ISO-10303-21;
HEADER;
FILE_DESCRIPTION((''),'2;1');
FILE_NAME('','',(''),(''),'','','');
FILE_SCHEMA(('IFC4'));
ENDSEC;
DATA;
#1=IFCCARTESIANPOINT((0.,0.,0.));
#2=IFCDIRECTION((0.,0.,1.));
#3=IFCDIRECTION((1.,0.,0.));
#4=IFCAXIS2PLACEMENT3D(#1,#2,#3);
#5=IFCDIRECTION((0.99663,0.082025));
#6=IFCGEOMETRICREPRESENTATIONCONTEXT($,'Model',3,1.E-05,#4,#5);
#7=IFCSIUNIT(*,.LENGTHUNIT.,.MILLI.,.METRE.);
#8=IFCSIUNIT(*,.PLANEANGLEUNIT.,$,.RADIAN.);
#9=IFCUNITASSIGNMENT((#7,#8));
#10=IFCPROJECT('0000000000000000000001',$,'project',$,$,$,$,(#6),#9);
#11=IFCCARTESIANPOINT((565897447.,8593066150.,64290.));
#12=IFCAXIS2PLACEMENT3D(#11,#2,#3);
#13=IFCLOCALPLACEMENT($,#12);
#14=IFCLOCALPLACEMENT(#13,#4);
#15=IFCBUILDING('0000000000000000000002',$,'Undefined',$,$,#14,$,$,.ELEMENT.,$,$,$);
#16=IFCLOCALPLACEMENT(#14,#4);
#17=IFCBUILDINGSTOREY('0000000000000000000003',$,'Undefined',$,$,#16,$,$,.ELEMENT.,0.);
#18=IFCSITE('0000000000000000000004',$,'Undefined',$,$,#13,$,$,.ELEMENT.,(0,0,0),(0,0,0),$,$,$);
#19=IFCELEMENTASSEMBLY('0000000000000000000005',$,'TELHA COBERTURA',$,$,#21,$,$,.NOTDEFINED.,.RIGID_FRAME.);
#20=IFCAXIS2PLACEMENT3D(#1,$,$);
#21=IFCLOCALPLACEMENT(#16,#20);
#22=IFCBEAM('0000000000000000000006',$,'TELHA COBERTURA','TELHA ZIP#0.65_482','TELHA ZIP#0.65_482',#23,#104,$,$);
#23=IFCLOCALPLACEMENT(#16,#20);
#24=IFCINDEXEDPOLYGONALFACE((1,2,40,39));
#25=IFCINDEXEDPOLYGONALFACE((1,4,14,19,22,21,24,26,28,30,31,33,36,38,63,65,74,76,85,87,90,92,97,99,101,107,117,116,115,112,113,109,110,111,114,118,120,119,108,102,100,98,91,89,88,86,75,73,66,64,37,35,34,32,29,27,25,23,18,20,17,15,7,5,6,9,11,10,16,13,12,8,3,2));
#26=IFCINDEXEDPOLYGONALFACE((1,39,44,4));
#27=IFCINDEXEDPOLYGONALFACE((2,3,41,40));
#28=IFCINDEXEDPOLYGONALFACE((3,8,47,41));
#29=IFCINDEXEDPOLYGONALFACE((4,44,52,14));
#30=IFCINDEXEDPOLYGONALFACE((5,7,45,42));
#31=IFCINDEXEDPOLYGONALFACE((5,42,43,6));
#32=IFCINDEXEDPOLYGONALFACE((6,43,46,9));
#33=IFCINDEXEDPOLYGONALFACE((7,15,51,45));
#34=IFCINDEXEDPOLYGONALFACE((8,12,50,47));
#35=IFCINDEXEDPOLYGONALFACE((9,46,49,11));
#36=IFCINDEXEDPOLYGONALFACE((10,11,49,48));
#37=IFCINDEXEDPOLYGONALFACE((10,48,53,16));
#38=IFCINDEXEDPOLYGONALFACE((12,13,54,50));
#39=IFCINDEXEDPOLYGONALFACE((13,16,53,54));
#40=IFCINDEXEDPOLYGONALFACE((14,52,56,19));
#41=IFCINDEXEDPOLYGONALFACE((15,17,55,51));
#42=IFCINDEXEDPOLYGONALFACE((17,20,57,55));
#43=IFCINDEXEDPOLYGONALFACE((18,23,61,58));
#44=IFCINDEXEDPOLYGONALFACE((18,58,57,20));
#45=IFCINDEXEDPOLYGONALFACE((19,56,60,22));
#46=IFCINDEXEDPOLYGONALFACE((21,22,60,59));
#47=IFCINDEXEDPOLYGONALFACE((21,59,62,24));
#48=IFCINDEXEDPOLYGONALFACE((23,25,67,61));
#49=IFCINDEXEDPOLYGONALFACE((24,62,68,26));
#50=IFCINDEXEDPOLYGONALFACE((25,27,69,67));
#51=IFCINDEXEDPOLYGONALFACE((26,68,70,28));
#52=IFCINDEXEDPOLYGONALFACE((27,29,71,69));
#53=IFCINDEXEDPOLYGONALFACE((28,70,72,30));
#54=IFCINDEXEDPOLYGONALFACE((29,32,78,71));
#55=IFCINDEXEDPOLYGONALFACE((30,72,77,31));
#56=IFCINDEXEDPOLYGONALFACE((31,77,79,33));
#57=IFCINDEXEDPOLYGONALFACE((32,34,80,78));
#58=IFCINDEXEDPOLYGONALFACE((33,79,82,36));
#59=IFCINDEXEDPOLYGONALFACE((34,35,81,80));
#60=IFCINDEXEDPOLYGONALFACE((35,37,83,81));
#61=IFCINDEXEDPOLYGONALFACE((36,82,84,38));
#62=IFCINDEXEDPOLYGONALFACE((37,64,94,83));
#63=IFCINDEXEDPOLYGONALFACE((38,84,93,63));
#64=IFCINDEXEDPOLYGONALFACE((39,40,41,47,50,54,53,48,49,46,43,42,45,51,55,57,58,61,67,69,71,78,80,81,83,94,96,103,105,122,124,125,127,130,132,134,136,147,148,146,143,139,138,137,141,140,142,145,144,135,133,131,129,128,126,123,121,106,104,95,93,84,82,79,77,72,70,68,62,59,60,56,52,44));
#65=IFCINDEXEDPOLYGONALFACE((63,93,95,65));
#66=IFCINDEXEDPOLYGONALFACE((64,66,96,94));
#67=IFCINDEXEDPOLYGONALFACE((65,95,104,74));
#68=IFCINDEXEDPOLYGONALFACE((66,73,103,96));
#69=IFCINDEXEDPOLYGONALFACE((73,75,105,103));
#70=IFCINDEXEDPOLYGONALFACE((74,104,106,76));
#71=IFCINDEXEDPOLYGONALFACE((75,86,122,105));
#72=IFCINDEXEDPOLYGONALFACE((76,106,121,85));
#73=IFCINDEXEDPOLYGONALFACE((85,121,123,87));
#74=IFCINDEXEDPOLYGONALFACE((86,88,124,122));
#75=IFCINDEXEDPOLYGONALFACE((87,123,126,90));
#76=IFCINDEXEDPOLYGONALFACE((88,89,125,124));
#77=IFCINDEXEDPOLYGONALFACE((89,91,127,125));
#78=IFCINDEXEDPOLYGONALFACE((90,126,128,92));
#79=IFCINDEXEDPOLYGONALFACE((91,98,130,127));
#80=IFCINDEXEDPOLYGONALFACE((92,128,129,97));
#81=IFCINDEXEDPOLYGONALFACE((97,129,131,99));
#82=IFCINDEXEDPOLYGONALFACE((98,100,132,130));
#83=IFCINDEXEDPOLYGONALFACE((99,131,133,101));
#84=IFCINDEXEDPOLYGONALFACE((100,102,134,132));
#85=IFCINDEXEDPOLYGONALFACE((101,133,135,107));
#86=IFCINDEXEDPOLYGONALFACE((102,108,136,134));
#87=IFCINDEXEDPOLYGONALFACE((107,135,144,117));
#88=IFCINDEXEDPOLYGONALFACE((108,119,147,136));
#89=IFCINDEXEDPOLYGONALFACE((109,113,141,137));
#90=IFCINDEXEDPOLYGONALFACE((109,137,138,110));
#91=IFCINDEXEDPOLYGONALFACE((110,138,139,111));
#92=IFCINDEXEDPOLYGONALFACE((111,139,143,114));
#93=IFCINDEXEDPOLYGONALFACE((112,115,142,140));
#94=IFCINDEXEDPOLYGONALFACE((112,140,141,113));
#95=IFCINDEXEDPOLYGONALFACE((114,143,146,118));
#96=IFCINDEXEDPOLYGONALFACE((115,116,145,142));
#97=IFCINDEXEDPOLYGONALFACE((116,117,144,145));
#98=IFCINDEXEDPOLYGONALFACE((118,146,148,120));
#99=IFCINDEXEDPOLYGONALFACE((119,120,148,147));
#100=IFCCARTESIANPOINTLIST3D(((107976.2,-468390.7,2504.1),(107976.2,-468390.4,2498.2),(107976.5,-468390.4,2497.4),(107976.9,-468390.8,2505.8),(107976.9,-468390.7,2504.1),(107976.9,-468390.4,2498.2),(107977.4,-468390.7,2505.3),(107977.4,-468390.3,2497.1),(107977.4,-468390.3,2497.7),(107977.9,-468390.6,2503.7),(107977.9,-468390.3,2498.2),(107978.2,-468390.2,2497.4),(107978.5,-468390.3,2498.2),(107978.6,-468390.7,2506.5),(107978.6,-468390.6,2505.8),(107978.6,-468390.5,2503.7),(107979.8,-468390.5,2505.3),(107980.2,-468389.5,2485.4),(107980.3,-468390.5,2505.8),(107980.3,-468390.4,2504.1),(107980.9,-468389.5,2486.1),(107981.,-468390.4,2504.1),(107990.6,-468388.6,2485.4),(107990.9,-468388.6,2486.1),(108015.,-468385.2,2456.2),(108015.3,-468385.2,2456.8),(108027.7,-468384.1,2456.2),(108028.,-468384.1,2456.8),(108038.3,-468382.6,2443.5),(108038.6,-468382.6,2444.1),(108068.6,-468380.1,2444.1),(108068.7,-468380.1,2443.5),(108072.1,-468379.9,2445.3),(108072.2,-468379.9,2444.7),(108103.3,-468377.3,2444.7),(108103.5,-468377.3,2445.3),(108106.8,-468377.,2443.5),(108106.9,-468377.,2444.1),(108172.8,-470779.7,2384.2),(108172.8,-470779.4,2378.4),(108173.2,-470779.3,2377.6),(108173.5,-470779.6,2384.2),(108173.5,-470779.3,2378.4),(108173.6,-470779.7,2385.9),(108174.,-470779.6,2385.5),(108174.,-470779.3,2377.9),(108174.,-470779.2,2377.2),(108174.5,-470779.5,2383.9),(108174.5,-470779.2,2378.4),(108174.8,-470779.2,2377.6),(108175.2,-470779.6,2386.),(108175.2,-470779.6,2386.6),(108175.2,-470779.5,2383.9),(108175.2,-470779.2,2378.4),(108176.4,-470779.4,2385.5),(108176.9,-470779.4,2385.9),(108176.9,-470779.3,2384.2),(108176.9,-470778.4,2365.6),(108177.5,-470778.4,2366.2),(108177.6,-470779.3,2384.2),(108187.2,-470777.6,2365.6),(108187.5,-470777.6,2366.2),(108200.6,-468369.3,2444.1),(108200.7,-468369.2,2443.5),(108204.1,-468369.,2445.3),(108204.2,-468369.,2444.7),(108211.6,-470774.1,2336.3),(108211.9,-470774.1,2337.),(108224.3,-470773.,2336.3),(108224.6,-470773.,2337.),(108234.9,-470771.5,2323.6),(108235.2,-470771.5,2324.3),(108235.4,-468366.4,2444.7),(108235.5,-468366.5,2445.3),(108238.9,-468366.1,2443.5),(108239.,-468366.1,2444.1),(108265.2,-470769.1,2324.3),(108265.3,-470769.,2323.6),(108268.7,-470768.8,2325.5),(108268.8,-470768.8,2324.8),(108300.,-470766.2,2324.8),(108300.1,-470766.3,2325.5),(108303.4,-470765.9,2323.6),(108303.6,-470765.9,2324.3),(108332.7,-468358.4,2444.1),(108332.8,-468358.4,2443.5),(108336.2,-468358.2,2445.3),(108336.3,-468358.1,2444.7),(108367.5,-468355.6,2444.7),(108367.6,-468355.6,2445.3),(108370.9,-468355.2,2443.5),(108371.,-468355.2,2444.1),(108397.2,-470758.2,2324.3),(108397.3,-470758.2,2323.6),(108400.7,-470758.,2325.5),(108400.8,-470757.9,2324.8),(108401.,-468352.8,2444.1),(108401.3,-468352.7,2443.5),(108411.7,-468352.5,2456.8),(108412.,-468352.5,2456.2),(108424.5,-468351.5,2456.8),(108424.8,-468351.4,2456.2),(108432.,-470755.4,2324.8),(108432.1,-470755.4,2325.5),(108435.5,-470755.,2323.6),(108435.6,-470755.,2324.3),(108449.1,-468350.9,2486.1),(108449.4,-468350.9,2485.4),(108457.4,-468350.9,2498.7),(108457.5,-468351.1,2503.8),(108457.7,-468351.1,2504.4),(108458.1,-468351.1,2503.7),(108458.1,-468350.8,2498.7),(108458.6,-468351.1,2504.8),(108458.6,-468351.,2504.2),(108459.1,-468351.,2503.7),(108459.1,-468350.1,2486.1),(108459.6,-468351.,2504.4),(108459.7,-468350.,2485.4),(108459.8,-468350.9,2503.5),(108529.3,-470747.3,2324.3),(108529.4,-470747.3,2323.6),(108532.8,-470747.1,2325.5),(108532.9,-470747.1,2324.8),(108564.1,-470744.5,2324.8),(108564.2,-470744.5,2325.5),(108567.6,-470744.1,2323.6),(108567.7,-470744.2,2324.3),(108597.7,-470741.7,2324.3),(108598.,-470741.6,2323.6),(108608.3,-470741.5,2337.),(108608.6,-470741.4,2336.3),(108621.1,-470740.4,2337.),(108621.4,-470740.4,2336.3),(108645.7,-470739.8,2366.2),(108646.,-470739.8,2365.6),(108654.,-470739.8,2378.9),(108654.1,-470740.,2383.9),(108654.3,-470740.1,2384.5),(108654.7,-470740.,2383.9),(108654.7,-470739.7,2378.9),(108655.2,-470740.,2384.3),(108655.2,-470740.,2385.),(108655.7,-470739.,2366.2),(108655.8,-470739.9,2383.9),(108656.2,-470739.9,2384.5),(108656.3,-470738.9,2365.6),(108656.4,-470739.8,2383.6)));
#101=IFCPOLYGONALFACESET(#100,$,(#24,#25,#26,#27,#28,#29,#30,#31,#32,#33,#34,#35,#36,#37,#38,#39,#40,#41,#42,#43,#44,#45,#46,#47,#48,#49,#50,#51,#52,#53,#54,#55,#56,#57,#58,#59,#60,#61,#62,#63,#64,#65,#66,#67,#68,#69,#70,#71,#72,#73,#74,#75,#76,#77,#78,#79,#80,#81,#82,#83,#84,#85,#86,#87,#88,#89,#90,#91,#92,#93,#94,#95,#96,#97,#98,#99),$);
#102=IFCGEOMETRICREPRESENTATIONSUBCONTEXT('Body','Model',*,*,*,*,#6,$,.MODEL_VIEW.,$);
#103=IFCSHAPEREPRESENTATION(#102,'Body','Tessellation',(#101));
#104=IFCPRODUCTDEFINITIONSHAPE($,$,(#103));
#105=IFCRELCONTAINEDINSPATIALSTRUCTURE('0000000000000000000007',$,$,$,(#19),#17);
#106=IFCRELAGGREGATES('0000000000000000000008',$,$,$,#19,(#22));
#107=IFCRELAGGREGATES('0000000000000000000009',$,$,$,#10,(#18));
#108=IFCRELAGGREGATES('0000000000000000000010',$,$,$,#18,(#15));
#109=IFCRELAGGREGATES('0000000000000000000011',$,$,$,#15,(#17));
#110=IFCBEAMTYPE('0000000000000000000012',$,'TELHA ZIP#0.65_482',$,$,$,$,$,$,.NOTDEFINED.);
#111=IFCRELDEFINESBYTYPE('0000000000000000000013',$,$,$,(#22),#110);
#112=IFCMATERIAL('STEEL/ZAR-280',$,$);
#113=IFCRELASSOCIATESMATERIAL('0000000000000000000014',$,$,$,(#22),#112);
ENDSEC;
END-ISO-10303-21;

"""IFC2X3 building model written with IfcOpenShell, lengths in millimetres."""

from ifc_helpers import new_model, si_unit, direction, frame, origin_with_axes, place, context, subcontext, project, spatial, polyline, outline, extrude, material, type_object, element, aggregate, save


model = new_model("IFC2X3")

# Units and contexts
model_context = context("Model", 3, precision=1e-05, world=origin_with_axes(), true_north=direction((0.99663, 0.082025)))
body_context = subcontext(model_context, "Body", "Model", "MODEL_VIEW")
ifc_project = project(units=[si_unit("LENGTHUNIT", "METRE", prefix="MILLI"), si_unit("PLANEANGLEUNIT", "RADIAN")], contexts=[model_context])

# Site, building, storey
site_placement = place(None, frame((565897447.0, 8593066150.0, 64290.0), z_axis=(0.0, 0.0, 1.0), x_axis=(1.0, 0.0, 0.0)))
site = spatial("IfcSite", under=ifc_project, at=site_placement, Name="Undefined", CompositionType="ELEMENT", RefLatitude=(0, 0, 0), RefLongitude=(0, 0, 0))
building_placement = place(site_placement, origin_with_axes())
building = spatial("IfcBuilding", under=site, at=building_placement, Name="Undefined", CompositionType="ELEMENT")
storey_placement = place(building_placement, origin_with_axes())
storey = spatial("IfcBuildingStorey", under=building, at=storey_placement, Name="Undefined", CompositionType="ELEMENT", Elevation=0.0)

# Element assembly, beam
ifc_material_1 = material(Name="STEEL/ZAR-280")
beam_type_1 = type_object("IfcBeamType", Name="TELHA ZIP#0.65_482", PredefinedType="NOTDEFINED")
assembly_1_placement = place(storey_placement, origin_with_axes())
assembly_1 = element("IfcElementAssembly", 1, at=assembly_1_placement, inside=storey, Name="TELHA COBERTURA", AssemblyPlace="NOTDEFINED", PredefinedType="RIGID_FRAME")
beam_1_placement = place(assembly_1_placement, frame((108414.5, -470758.3, 2354.8), z_axis=(0.004096, -0.049769, 0.998752), x_axis=(-0.081923, 0.995387, 0.049938)))
beam_1 = element("IfcBeam", 2, at=beam_1_placement, type_object=beam_type_1, material=ifc_material_1, Name="TELHA COBERTURA", Description="TELHA ZIP#0.65_482", ObjectType="TELHA ZIP#0.65_482", context=body_context, shape_type="SweptSolid", body=[
    extrude(outline(polyline([(240.5, 29.7), (241.4, 30.2), (242.4, 29.7), (242.6, 28.9), (242.6, 10.8), (232.2, 10.8), (207.6, -18.5), (194.9, -18.5), (184.2, -31.2), (153.7, -31.2), (150.2, -30.0), (118.9, -30.0), (115.4, -31.2), (21.2, -31.2), (17.7, -30.0), (-13.6, -30.0), (-17.1, -31.2), (-111.3, -31.2), (-114.8, -30.0), (-146.1, -30.0), (-149.6, -31.2), (-180.1, -31.2), (-190.8, -18.5), (-203.6, -18.5), (-228.1, 10.8), (-238.5, 10.8), (-238.5, 29.5), (-239.0, 30.7), (-240.2, 31.2), (-241.4, 30.7), (-241.9, 29.5), (-241.9, 23.6), (-241.4, 23.1), (-240.9, 23.6), (-240.9, 29.1), (-240.2, 29.1), (-240.2, 23.6), (-240.6, 22.8), (-241.4, 22.4), (-242.3, 22.8), (-242.6, 23.6), (-242.6, 29.5), (-241.9, 31.2), (-240.2, 31.9), (-238.5, 31.2), (-237.9, 29.5), (-237.9, 11.4), (-227.8, 11.4), (-203.2, -17.9), (-190.4, -17.9), (-179.8, -30.5), (-149.7, -30.5), (-146.2, -29.4), (-114.7, -29.4), (-111.2, -30.5), (-17.2, -30.5), (-13.7, -29.4), (17.8, -29.4), (21.3, -30.5), (115.3, -30.5), (118.8, -29.4), (150.3, -29.4), (153.8, -30.5), (183.9, -30.5), (194.6, -17.9), (207.4, -17.9), (231.9, 11.4), (241.9, 11.4), (241.9, 29.1), (241.4, 29.5), (240.9, 29.1), (240.9, 24.1), (240.2, 24.1), (240.2, 29.2), (240.5, 29.7)])), frame((2400.0, 0.0, 0.0), z_axis=(-1.0, 0.0, 0.0), x_axis=(0.0, -1.0, 0.0)), (0.0, 0.0, 1.0), 2400.0),
])
aggregate(assembly_1, [beam_1])

save(model, "model.ifc")
